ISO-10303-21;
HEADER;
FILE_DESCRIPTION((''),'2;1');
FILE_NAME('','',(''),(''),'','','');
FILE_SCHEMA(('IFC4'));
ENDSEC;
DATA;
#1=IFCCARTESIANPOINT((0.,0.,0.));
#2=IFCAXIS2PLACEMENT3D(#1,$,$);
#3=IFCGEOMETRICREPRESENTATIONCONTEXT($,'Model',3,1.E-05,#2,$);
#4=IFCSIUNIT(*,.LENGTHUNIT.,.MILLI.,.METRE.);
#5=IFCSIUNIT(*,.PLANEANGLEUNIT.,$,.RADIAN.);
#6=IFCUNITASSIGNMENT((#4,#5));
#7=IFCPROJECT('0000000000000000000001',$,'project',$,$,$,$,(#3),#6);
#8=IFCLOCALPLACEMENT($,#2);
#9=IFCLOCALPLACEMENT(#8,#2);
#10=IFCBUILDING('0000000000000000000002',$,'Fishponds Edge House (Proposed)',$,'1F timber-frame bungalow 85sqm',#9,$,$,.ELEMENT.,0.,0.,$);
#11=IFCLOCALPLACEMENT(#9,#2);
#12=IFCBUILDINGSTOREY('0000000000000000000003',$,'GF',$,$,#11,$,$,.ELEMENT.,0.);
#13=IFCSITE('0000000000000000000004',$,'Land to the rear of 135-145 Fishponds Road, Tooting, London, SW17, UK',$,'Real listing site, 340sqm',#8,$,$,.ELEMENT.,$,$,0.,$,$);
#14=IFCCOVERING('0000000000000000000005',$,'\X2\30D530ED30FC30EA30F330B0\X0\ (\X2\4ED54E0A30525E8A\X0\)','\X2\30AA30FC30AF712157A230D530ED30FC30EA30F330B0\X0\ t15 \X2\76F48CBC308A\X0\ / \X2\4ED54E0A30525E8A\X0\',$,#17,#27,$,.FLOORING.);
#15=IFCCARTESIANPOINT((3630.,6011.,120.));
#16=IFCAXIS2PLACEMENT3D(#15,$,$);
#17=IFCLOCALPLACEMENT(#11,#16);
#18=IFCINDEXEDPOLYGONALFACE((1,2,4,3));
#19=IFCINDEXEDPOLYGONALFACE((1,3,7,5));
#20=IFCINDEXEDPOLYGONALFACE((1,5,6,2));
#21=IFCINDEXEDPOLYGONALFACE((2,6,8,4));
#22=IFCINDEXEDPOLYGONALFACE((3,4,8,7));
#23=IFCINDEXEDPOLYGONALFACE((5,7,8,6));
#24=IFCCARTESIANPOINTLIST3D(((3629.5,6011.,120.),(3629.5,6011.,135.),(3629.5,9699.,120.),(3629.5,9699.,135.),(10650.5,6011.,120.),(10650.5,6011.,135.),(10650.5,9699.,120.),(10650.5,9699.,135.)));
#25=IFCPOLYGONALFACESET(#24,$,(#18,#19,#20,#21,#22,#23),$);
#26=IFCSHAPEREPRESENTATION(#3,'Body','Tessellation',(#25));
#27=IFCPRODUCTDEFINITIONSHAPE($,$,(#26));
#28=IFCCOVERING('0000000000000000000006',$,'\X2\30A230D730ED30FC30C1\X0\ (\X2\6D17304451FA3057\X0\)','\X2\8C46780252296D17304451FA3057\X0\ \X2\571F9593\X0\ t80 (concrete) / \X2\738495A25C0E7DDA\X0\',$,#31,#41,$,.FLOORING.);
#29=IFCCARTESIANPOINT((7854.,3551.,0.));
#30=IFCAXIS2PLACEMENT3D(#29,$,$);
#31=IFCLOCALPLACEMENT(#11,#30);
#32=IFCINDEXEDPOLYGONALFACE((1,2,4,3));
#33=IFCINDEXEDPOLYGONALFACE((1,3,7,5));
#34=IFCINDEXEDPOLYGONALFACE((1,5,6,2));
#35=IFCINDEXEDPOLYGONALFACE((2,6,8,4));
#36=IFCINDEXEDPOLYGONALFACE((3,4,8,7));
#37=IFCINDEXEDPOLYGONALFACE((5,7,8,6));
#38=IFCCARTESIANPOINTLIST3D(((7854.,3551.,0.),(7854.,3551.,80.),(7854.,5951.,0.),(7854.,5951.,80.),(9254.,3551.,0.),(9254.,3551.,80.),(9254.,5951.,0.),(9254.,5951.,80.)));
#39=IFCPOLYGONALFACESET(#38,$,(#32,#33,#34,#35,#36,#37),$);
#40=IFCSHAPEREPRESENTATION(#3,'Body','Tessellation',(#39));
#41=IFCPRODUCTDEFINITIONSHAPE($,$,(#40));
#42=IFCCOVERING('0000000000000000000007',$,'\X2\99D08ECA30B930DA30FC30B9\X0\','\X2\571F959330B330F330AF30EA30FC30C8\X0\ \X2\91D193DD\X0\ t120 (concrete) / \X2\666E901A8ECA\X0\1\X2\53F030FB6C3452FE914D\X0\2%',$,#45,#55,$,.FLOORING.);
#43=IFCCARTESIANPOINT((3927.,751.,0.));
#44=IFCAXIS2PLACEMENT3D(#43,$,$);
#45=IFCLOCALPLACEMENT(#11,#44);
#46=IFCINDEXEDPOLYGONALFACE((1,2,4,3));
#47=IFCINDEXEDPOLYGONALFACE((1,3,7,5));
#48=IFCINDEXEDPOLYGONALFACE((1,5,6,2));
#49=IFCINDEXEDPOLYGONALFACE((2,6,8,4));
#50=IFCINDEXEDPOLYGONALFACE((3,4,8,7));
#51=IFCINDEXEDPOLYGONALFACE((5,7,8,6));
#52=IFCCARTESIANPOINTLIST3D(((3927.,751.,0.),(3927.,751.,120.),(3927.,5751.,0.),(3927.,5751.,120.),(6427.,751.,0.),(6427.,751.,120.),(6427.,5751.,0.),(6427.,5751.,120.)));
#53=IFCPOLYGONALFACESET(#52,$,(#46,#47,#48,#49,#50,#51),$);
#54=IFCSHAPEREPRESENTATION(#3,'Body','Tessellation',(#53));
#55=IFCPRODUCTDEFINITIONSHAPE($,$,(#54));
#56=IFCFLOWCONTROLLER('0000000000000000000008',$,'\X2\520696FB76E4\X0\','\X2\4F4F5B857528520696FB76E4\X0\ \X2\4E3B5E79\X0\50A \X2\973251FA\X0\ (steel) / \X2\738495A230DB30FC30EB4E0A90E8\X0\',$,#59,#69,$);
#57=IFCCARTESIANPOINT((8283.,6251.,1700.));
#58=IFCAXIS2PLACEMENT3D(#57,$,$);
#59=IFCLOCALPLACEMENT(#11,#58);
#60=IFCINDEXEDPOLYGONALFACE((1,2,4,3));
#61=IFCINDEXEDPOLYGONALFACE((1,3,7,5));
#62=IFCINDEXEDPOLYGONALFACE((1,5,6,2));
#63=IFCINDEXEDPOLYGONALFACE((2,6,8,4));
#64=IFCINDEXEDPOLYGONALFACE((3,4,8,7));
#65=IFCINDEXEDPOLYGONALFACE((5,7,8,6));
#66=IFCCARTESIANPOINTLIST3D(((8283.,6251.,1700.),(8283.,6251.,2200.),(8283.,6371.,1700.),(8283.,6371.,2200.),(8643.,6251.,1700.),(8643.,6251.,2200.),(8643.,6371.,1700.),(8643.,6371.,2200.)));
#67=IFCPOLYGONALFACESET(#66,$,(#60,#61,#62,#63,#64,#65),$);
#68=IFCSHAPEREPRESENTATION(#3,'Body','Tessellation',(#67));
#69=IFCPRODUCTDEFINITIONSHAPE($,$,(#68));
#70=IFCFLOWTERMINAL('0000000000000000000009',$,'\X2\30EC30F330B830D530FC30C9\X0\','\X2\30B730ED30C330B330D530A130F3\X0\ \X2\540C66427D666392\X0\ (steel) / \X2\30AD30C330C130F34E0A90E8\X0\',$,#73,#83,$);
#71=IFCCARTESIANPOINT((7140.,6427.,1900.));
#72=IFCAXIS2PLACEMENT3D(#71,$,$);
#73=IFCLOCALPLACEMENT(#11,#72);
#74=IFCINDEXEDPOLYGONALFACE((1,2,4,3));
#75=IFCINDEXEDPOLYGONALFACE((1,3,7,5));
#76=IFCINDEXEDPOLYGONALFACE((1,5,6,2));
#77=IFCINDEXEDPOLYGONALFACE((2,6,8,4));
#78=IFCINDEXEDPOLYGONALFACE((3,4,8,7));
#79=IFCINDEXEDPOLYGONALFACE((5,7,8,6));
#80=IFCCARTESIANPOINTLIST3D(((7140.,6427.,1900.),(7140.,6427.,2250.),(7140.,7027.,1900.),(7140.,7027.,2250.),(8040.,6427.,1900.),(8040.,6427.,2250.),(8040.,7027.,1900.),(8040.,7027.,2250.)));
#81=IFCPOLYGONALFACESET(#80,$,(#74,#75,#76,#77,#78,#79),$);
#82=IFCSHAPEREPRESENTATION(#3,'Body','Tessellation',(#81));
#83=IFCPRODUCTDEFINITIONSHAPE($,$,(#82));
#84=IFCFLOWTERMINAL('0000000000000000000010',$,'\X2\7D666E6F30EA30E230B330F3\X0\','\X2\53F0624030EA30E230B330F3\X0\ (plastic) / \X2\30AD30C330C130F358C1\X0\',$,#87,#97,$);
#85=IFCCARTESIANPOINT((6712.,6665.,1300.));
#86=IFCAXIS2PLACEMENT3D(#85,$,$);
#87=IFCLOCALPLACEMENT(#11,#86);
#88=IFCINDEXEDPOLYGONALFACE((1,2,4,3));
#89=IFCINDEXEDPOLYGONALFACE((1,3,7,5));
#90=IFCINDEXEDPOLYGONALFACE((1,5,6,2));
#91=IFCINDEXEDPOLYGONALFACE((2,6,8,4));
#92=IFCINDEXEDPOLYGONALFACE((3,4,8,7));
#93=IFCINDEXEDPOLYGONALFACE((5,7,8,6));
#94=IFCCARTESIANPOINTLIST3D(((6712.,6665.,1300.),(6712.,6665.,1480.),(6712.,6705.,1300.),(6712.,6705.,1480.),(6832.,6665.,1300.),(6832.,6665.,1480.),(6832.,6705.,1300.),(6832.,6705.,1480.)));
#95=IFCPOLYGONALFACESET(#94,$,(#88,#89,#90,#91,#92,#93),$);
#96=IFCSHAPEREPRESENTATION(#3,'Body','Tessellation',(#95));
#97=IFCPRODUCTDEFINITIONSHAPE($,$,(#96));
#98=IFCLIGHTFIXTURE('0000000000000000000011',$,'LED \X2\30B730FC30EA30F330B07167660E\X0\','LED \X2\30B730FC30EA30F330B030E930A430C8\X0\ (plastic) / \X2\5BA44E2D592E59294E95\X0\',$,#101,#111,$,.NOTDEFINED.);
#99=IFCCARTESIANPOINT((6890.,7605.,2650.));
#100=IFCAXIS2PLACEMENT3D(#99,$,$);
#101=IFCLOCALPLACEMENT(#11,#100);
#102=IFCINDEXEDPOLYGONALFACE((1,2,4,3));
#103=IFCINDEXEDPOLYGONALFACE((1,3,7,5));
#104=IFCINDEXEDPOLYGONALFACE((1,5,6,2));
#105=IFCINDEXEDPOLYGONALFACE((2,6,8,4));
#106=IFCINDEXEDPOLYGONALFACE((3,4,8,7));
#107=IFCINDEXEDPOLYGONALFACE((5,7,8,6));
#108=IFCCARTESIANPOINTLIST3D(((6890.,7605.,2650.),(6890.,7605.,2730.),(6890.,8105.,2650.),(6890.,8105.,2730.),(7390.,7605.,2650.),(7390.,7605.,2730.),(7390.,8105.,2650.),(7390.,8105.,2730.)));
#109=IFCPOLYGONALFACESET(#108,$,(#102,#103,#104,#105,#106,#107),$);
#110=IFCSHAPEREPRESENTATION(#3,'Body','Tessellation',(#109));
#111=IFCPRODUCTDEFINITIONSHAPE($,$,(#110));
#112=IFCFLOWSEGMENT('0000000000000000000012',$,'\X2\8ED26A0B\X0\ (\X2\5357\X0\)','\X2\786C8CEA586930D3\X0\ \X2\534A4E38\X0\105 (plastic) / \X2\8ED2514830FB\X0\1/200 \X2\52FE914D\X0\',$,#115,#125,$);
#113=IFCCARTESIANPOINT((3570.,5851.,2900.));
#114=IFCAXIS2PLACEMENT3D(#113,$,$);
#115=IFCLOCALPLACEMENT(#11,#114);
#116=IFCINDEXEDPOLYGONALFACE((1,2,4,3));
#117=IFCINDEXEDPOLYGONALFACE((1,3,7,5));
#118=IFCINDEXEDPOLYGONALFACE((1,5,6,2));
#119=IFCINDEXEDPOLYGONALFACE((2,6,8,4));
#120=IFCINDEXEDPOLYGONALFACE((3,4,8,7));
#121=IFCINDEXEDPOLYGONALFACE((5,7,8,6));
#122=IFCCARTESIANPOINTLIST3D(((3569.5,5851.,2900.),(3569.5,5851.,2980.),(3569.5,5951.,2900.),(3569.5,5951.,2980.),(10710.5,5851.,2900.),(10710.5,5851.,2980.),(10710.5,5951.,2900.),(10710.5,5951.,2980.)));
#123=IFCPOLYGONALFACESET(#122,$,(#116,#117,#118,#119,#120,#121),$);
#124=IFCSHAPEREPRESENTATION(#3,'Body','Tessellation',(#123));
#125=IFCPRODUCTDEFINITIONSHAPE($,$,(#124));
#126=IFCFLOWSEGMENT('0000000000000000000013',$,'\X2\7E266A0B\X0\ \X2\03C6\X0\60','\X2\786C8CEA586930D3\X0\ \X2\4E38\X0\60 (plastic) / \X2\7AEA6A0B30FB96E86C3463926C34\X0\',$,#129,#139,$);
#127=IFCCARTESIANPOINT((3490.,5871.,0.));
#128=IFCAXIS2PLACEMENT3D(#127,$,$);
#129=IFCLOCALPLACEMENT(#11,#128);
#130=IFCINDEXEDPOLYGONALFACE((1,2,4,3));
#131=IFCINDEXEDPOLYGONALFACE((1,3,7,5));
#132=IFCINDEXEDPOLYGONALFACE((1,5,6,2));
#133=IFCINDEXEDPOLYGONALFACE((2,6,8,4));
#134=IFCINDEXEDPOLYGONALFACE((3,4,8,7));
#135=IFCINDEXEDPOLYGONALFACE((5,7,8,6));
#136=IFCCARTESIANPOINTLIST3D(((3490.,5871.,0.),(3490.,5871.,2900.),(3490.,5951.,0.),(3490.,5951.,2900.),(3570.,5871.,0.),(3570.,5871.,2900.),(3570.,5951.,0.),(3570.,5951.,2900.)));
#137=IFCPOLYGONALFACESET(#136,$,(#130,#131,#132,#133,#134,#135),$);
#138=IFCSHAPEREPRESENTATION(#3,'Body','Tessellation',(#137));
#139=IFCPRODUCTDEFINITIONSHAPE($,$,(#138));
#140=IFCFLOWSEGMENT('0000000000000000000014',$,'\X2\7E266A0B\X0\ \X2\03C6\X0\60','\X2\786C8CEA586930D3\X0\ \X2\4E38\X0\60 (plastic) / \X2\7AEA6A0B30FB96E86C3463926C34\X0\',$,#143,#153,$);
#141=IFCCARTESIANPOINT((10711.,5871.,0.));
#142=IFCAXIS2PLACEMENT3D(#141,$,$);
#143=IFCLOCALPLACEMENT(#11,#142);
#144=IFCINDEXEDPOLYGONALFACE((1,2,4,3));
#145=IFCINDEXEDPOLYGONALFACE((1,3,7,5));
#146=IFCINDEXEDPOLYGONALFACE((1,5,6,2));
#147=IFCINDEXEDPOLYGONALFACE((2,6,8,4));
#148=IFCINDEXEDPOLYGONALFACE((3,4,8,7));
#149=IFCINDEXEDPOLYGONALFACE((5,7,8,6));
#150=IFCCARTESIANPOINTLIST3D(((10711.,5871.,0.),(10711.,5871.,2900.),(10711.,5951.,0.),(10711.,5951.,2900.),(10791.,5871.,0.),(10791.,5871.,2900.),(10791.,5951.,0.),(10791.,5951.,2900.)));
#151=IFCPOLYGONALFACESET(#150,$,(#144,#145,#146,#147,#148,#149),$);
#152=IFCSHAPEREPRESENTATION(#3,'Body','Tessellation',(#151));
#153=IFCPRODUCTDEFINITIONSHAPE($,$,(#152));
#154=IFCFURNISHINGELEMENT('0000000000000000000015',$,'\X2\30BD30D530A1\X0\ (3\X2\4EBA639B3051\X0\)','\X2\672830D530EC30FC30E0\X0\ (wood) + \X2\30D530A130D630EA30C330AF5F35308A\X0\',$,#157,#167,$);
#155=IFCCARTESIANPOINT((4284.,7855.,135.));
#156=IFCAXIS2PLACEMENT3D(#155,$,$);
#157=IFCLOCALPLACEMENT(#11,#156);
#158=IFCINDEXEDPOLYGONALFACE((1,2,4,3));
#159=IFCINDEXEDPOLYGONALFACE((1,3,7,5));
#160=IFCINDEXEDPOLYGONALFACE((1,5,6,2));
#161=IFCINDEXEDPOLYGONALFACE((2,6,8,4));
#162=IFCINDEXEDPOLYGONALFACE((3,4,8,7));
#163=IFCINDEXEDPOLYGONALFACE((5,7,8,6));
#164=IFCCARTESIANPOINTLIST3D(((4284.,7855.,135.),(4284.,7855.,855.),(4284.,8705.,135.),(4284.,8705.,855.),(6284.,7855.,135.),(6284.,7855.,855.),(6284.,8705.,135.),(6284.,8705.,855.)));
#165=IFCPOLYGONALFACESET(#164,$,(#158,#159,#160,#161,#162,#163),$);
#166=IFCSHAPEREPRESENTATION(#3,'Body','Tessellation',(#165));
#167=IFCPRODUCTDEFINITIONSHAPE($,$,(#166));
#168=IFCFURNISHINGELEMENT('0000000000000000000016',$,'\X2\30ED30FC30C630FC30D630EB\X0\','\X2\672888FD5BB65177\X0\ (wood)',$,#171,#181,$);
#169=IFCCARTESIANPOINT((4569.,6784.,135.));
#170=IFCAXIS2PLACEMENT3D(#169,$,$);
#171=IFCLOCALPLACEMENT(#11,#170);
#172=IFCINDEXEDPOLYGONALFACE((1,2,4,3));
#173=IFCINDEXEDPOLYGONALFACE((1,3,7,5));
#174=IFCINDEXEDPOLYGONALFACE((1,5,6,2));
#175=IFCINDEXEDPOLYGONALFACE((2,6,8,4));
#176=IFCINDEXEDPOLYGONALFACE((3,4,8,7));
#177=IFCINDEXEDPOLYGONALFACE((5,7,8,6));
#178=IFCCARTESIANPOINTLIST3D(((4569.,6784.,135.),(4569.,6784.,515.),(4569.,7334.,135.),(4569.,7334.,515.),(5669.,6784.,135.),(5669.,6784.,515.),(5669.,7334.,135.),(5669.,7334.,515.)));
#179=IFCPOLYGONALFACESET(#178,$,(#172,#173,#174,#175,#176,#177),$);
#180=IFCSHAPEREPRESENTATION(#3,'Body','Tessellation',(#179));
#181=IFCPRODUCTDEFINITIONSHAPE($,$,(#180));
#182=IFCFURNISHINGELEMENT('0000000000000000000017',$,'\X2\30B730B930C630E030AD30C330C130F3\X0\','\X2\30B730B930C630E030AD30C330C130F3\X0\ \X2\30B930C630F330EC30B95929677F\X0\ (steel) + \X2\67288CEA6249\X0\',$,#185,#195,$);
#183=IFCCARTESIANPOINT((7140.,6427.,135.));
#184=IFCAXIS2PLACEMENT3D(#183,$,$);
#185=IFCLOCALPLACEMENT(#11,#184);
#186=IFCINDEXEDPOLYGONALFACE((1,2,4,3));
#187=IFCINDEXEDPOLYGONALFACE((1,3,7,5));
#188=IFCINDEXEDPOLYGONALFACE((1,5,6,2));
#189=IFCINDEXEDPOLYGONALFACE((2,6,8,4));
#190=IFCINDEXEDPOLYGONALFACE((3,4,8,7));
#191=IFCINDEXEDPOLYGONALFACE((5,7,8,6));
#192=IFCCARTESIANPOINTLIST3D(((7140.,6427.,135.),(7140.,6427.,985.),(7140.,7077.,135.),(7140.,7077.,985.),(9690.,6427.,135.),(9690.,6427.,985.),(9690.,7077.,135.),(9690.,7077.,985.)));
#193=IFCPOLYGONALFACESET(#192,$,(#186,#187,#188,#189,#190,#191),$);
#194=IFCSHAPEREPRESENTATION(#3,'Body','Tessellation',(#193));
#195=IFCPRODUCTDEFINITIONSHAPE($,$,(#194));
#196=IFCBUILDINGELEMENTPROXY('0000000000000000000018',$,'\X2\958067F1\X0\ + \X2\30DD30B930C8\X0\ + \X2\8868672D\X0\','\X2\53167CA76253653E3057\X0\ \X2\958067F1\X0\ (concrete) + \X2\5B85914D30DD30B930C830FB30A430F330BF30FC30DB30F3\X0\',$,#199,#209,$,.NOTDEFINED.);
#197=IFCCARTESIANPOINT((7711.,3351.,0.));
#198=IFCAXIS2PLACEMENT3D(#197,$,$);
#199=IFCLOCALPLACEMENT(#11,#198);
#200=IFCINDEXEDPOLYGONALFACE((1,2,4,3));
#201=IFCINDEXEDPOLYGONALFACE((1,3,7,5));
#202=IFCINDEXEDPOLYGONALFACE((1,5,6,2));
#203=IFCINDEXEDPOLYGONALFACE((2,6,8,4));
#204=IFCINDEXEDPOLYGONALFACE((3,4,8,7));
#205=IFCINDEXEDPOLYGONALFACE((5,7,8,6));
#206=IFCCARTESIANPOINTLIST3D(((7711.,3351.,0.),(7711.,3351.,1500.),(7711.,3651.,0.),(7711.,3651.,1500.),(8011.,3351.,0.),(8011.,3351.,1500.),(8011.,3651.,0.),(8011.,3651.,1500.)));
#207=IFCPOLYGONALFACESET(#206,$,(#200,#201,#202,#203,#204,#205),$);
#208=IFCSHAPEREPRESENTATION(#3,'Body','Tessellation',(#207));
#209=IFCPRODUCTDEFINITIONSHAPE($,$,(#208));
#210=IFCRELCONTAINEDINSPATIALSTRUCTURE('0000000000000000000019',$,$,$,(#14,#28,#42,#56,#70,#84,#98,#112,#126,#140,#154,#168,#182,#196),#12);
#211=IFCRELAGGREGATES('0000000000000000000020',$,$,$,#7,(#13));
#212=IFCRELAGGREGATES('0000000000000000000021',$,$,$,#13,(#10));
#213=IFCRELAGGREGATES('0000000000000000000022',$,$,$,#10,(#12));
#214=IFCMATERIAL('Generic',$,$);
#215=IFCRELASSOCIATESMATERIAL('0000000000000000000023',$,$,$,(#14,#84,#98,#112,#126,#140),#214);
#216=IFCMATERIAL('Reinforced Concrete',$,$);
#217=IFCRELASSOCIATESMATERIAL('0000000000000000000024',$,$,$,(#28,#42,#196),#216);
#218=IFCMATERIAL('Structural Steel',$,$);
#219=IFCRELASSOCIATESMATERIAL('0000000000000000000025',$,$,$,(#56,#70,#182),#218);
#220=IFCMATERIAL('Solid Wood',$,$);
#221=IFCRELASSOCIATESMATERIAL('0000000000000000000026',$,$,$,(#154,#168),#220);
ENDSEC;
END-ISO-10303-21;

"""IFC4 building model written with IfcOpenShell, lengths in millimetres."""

from ifc_helpers import new_model, si_unit, frame, frame_2d, origin, place, context, project, spatial, rectangle, extrude, material, element, save


model = new_model("IFC4")

# Units and contexts
model_context = context("Model", 3, precision=1e-05, world=origin())
ifc_project = project(units=[si_unit("LENGTHUNIT", "METRE", prefix="MILLI"), si_unit("PLANEANGLEUNIT", "RADIAN")], contexts=[model_context])

# Site, building, storey
site_placement = place(None, origin())
site = spatial("IfcSite", under=ifc_project, at=site_placement, Name="Land to the rear of 135-145 Fishponds Road, Tooting, London, SW17, UK", ObjectType="Real listing site, 340sqm", CompositionType="ELEMENT", RefElevation=0.0)
building_placement = place(site_placement, origin())
building = spatial("IfcBuilding", under=site, at=building_placement, Name="Fishponds Edge House (Proposed)", ObjectType="1F timber-frame bungalow 85sqm", CompositionType="ELEMENT", ElevationOfRefHeight=0.0, ElevationOfTerrain=0.0)
storey_placement = place(building_placement, origin())
storey = spatial("IfcBuildingStorey", under=building, at=storey_placement, Name="GF", CompositionType="ELEMENT", Elevation=0.0)

# Shared definitions
ifc_material_1 = material(Name="Solid Wood")

# Shared definitions
ifc_material_2 = material(Name="Reinforced Concrete")

# Shared definitions
ifc_material_3 = material(Name="Structural Steel")

# Coverings
ifc_material_4 = material(Name="Generic")
covering_1_placement = place(storey_placement, frame((3630.0, 6011.0, 120.0)))
element("IfcCovering", 1, at=covering_1_placement, inside=storey, material=ifc_material_4, Name="フローリング (仕上げ床)", Description="オーク無垢フローリング t15 直貼り / 仕上げ床", PredefinedType="FLOORING", context=model_context, shape_type="SweptSolid", body=[
    extrude(rectangle(XDim=7021.0, YDim=3688.0, at=frame_2d((3510.0, 1844.0))), frame((3630.0, 6011.0, 120.0)), (0.0, 0.0, 1.0), 15.0),
])
covering_2_placement = place(storey_placement, frame((7854.0, 3551.0, 0.0)))
element("IfcCovering", 2, at=covering_2_placement, inside=storey, material=ifc_material_2, Name="アプローチ (洗い出し)", Description="豆砂利洗い出し 土間 t80 (concrete) / 玄関導線", PredefinedType="FLOORING", context=model_context, shape_type="SweptSolid", body=[
    extrude(rectangle(XDim=1400.0, YDim=2400.0, at=frame_2d((700.0, 1200.0))), frame((7854.0, 3551.0, 0.0)), (0.0, 0.0, 1.0), 80.0),
])
covering_3_placement = place(storey_placement, frame((3927.0, 751.0, 0.0)))
element("IfcCovering", 3, at=covering_3_placement, inside=storey, material=ifc_material_2, Name="駐車スペース", Description="土間コンクリート 金鏝 t120 (concrete) / 普通車1台・水勾配2%", PredefinedType="FLOORING", context=model_context, shape_type="SweptSolid", body=[
    extrude(rectangle(XDim=2500.0, YDim=5000.0, at=frame_2d((1250.0, 2500.0))), frame((3927.0, 751.0, 0.0)), (0.0, 0.0, 1.0), 120.0),
])

# Flow controller
flow_controller_placement = place(storey_placement, frame((8283.0, 6251.0, 1700.0)))
element("IfcFlowController", 4, at=flow_controller_placement, inside=storey, material=ifc_material_3, Name="分電盤", Description="住宅用分電盤 主幹50A 露出 (steel) / 玄関ホール上部", context=model_context, shape_type="SweptSolid", body=[
    extrude(rectangle(XDim=360.0, YDim=120.0, at=frame_2d((180.0, 60.0))), frame((8283.0, 6251.0, 1700.0)), (0.0, 0.0, 1.0), 500.0),
])

# Flow terminals
flow_terminal_1_placement = place(storey_placement, frame((7140.0, 6427.0, 1900.0)))
element("IfcFlowTerminal", 5, at=flow_terminal_1_placement, inside=storey, material=ifc_material_3, Name="レンジフード", Description="シロッコファン 同時給排 (steel) / キッチン上部", context=model_context, shape_type="SweptSolid", body=[
    extrude(rectangle(XDim=900.0, YDim=600.0, at=frame_2d((450.0, 300.0))), frame((7140.0, 6427.0, 1900.0)), (0.0, 0.0, 1.0), 350.0),
])
flow_terminal_2_placement = place(storey_placement, frame((6712.0, 6665.0, 1300.0)))
element("IfcFlowTerminal", 6, at=flow_terminal_2_placement, inside=storey, material=ifc_material_4, Name="給湯リモコン", Description="台所リモコン (plastic) / キッチン壁", context=model_context, shape_type="SweptSolid", body=[
    extrude(rectangle(XDim=120.0, YDim=40.0, at=frame_2d((60.0, 20.0))), frame((6712.0, 6665.0, 1300.0)), (0.0, 0.0, 1.0), 180.0),
])

# Light fixture
light_fixture_placement = place(storey_placement, frame((6890.0, 7605.0, 2650.0)))
element("IfcLightFixture", 7, at=light_fixture_placement, inside=storey, material=ifc_material_4, Name="LED シーリング照明", Description="LED シーリングライト (plastic) / 室中央天井", PredefinedType="NOTDEFINED", context=model_context, shape_type="SweptSolid", body=[
    extrude(rectangle(XDim=500.0, YDim=500.0, at=frame_2d((250.0, 250.0))), frame((6890.0, 7605.0, 2650.0)), (0.0, 0.0, 1.0), 80.0),
])

# Flow segments
flow_segment_1_placement = place(storey_placement, frame((3570.0, 5851.0, 2900.0)))
element("IfcFlowSegment", 8, at=flow_segment_1_placement, inside=storey, material=ifc_material_4, Name="軒樋 (南)", Description="硬質塩ビ 半丸105 (plastic) / 軒先・1/200 勾配", context=model_context, shape_type="SweptSolid", body=[
    extrude(rectangle(XDim=7141.0, YDim=100.0, at=frame_2d((3570.0, 50.0))), frame((3570.0, 5851.0, 2900.0)), (0.0, 0.0, 1.0), 80.0),
])
flow_segment_2_placement = place(storey_placement, frame((3490.0, 5871.0, 0.0)))
element("IfcFlowSegment", 9, at=flow_segment_2_placement, inside=storey, material=ifc_material_4, Name="縦樋 φ60", Description="硬質塩ビ 丸60 (plastic) / 竪樋・雨水排水", context=model_context, shape_type="SweptSolid", body=[
    extrude(rectangle(XDim=80.0, YDim=80.0, at=frame_2d((40.0, 40.0))), frame((3490.0, 5871.0, 0.0)), (0.0, 0.0, 1.0), 2900.0),
])
flow_segment_3_placement = place(storey_placement, frame((10711.0, 5871.0, 0.0)))
element("IfcFlowSegment", 10, at=flow_segment_3_placement, inside=storey, material=ifc_material_4, Name="縦樋 φ60", Description="硬質塩ビ 丸60 (plastic) / 竪樋・雨水排水", context=model_context, shape_type="SweptSolid", body=[
    extrude(rectangle(XDim=80.0, YDim=80.0, at=frame_2d((40.0, 40.0))), frame((10711.0, 5871.0, 0.0)), (0.0, 0.0, 1.0), 2900.0),
])

# Furnishing elements
furnishing_1_placement = place(storey_placement, frame((4284.0, 7855.0, 135.0)))
element("IfcFurnishingElement", 11, at=furnishing_1_placement, inside=storey, material=ifc_material_1, Name="ソファ (3人掛け)", Description="木フレーム (wood) + ファブリック張り", context=model_context, shape_type="SweptSolid", body=[
    extrude(rectangle(XDim=2000.0, YDim=850.0, at=frame_2d((1000.0, 425.0))), frame((4284.0, 7855.0, 135.0)), (0.0, 0.0, 1.0), 720.0),
])
furnishing_2_placement = place(storey_placement, frame((4569.0, 6784.0, 135.0)))
element("IfcFurnishingElement", 12, at=furnishing_2_placement, inside=storey, material=ifc_material_1, Name="ローテーブル", Description="木製家具 (wood)", context=model_context, shape_type="SweptSolid", body=[
    extrude(rectangle(XDim=1100.0, YDim=550.0, at=frame_2d((550.0, 275.0))), frame((4569.0, 6784.0, 135.0)), (0.0, 0.0, 1.0), 380.0),
])
furnishing_3_placement = place(storey_placement, frame((7140.0, 6427.0, 135.0)))
element("IfcFurnishingElement", 13, at=furnishing_3_placement, inside=storey, material=ifc_material_3, Name="システムキッチン", Description="システムキッチン ステンレス天板 (steel) + 木質扉", context=model_context, shape_type="SweptSolid", body=[
    extrude(rectangle(XDim=2550.0, YDim=650.0, at=frame_2d((1275.0, 325.0))), frame((7140.0, 6427.0, 135.0)), (0.0, 0.0, 1.0), 850.0),
])

# Building element proxy
proxy_placement = place(storey_placement, frame((7711.0, 3351.0, 0.0)))
element("IfcBuildingElementProxy", 14, at=proxy_placement, inside=storey, material=ifc_material_2, Name="門柱 + ポスト + 表札", Description="化粧打放し 門柱 (concrete) + 宅配ポスト・インターホン", PredefinedType="NOTDEFINED", context=model_context, shape_type="SweptSolid", body=[
    extrude(rectangle(XDim=300.0, YDim=300.0, at=frame_2d((150.0, 150.0))), frame((7711.0, 3351.0, 0.0)), (0.0, 0.0, 1.0), 1500.0),
])

save(model, "model.ifc")
